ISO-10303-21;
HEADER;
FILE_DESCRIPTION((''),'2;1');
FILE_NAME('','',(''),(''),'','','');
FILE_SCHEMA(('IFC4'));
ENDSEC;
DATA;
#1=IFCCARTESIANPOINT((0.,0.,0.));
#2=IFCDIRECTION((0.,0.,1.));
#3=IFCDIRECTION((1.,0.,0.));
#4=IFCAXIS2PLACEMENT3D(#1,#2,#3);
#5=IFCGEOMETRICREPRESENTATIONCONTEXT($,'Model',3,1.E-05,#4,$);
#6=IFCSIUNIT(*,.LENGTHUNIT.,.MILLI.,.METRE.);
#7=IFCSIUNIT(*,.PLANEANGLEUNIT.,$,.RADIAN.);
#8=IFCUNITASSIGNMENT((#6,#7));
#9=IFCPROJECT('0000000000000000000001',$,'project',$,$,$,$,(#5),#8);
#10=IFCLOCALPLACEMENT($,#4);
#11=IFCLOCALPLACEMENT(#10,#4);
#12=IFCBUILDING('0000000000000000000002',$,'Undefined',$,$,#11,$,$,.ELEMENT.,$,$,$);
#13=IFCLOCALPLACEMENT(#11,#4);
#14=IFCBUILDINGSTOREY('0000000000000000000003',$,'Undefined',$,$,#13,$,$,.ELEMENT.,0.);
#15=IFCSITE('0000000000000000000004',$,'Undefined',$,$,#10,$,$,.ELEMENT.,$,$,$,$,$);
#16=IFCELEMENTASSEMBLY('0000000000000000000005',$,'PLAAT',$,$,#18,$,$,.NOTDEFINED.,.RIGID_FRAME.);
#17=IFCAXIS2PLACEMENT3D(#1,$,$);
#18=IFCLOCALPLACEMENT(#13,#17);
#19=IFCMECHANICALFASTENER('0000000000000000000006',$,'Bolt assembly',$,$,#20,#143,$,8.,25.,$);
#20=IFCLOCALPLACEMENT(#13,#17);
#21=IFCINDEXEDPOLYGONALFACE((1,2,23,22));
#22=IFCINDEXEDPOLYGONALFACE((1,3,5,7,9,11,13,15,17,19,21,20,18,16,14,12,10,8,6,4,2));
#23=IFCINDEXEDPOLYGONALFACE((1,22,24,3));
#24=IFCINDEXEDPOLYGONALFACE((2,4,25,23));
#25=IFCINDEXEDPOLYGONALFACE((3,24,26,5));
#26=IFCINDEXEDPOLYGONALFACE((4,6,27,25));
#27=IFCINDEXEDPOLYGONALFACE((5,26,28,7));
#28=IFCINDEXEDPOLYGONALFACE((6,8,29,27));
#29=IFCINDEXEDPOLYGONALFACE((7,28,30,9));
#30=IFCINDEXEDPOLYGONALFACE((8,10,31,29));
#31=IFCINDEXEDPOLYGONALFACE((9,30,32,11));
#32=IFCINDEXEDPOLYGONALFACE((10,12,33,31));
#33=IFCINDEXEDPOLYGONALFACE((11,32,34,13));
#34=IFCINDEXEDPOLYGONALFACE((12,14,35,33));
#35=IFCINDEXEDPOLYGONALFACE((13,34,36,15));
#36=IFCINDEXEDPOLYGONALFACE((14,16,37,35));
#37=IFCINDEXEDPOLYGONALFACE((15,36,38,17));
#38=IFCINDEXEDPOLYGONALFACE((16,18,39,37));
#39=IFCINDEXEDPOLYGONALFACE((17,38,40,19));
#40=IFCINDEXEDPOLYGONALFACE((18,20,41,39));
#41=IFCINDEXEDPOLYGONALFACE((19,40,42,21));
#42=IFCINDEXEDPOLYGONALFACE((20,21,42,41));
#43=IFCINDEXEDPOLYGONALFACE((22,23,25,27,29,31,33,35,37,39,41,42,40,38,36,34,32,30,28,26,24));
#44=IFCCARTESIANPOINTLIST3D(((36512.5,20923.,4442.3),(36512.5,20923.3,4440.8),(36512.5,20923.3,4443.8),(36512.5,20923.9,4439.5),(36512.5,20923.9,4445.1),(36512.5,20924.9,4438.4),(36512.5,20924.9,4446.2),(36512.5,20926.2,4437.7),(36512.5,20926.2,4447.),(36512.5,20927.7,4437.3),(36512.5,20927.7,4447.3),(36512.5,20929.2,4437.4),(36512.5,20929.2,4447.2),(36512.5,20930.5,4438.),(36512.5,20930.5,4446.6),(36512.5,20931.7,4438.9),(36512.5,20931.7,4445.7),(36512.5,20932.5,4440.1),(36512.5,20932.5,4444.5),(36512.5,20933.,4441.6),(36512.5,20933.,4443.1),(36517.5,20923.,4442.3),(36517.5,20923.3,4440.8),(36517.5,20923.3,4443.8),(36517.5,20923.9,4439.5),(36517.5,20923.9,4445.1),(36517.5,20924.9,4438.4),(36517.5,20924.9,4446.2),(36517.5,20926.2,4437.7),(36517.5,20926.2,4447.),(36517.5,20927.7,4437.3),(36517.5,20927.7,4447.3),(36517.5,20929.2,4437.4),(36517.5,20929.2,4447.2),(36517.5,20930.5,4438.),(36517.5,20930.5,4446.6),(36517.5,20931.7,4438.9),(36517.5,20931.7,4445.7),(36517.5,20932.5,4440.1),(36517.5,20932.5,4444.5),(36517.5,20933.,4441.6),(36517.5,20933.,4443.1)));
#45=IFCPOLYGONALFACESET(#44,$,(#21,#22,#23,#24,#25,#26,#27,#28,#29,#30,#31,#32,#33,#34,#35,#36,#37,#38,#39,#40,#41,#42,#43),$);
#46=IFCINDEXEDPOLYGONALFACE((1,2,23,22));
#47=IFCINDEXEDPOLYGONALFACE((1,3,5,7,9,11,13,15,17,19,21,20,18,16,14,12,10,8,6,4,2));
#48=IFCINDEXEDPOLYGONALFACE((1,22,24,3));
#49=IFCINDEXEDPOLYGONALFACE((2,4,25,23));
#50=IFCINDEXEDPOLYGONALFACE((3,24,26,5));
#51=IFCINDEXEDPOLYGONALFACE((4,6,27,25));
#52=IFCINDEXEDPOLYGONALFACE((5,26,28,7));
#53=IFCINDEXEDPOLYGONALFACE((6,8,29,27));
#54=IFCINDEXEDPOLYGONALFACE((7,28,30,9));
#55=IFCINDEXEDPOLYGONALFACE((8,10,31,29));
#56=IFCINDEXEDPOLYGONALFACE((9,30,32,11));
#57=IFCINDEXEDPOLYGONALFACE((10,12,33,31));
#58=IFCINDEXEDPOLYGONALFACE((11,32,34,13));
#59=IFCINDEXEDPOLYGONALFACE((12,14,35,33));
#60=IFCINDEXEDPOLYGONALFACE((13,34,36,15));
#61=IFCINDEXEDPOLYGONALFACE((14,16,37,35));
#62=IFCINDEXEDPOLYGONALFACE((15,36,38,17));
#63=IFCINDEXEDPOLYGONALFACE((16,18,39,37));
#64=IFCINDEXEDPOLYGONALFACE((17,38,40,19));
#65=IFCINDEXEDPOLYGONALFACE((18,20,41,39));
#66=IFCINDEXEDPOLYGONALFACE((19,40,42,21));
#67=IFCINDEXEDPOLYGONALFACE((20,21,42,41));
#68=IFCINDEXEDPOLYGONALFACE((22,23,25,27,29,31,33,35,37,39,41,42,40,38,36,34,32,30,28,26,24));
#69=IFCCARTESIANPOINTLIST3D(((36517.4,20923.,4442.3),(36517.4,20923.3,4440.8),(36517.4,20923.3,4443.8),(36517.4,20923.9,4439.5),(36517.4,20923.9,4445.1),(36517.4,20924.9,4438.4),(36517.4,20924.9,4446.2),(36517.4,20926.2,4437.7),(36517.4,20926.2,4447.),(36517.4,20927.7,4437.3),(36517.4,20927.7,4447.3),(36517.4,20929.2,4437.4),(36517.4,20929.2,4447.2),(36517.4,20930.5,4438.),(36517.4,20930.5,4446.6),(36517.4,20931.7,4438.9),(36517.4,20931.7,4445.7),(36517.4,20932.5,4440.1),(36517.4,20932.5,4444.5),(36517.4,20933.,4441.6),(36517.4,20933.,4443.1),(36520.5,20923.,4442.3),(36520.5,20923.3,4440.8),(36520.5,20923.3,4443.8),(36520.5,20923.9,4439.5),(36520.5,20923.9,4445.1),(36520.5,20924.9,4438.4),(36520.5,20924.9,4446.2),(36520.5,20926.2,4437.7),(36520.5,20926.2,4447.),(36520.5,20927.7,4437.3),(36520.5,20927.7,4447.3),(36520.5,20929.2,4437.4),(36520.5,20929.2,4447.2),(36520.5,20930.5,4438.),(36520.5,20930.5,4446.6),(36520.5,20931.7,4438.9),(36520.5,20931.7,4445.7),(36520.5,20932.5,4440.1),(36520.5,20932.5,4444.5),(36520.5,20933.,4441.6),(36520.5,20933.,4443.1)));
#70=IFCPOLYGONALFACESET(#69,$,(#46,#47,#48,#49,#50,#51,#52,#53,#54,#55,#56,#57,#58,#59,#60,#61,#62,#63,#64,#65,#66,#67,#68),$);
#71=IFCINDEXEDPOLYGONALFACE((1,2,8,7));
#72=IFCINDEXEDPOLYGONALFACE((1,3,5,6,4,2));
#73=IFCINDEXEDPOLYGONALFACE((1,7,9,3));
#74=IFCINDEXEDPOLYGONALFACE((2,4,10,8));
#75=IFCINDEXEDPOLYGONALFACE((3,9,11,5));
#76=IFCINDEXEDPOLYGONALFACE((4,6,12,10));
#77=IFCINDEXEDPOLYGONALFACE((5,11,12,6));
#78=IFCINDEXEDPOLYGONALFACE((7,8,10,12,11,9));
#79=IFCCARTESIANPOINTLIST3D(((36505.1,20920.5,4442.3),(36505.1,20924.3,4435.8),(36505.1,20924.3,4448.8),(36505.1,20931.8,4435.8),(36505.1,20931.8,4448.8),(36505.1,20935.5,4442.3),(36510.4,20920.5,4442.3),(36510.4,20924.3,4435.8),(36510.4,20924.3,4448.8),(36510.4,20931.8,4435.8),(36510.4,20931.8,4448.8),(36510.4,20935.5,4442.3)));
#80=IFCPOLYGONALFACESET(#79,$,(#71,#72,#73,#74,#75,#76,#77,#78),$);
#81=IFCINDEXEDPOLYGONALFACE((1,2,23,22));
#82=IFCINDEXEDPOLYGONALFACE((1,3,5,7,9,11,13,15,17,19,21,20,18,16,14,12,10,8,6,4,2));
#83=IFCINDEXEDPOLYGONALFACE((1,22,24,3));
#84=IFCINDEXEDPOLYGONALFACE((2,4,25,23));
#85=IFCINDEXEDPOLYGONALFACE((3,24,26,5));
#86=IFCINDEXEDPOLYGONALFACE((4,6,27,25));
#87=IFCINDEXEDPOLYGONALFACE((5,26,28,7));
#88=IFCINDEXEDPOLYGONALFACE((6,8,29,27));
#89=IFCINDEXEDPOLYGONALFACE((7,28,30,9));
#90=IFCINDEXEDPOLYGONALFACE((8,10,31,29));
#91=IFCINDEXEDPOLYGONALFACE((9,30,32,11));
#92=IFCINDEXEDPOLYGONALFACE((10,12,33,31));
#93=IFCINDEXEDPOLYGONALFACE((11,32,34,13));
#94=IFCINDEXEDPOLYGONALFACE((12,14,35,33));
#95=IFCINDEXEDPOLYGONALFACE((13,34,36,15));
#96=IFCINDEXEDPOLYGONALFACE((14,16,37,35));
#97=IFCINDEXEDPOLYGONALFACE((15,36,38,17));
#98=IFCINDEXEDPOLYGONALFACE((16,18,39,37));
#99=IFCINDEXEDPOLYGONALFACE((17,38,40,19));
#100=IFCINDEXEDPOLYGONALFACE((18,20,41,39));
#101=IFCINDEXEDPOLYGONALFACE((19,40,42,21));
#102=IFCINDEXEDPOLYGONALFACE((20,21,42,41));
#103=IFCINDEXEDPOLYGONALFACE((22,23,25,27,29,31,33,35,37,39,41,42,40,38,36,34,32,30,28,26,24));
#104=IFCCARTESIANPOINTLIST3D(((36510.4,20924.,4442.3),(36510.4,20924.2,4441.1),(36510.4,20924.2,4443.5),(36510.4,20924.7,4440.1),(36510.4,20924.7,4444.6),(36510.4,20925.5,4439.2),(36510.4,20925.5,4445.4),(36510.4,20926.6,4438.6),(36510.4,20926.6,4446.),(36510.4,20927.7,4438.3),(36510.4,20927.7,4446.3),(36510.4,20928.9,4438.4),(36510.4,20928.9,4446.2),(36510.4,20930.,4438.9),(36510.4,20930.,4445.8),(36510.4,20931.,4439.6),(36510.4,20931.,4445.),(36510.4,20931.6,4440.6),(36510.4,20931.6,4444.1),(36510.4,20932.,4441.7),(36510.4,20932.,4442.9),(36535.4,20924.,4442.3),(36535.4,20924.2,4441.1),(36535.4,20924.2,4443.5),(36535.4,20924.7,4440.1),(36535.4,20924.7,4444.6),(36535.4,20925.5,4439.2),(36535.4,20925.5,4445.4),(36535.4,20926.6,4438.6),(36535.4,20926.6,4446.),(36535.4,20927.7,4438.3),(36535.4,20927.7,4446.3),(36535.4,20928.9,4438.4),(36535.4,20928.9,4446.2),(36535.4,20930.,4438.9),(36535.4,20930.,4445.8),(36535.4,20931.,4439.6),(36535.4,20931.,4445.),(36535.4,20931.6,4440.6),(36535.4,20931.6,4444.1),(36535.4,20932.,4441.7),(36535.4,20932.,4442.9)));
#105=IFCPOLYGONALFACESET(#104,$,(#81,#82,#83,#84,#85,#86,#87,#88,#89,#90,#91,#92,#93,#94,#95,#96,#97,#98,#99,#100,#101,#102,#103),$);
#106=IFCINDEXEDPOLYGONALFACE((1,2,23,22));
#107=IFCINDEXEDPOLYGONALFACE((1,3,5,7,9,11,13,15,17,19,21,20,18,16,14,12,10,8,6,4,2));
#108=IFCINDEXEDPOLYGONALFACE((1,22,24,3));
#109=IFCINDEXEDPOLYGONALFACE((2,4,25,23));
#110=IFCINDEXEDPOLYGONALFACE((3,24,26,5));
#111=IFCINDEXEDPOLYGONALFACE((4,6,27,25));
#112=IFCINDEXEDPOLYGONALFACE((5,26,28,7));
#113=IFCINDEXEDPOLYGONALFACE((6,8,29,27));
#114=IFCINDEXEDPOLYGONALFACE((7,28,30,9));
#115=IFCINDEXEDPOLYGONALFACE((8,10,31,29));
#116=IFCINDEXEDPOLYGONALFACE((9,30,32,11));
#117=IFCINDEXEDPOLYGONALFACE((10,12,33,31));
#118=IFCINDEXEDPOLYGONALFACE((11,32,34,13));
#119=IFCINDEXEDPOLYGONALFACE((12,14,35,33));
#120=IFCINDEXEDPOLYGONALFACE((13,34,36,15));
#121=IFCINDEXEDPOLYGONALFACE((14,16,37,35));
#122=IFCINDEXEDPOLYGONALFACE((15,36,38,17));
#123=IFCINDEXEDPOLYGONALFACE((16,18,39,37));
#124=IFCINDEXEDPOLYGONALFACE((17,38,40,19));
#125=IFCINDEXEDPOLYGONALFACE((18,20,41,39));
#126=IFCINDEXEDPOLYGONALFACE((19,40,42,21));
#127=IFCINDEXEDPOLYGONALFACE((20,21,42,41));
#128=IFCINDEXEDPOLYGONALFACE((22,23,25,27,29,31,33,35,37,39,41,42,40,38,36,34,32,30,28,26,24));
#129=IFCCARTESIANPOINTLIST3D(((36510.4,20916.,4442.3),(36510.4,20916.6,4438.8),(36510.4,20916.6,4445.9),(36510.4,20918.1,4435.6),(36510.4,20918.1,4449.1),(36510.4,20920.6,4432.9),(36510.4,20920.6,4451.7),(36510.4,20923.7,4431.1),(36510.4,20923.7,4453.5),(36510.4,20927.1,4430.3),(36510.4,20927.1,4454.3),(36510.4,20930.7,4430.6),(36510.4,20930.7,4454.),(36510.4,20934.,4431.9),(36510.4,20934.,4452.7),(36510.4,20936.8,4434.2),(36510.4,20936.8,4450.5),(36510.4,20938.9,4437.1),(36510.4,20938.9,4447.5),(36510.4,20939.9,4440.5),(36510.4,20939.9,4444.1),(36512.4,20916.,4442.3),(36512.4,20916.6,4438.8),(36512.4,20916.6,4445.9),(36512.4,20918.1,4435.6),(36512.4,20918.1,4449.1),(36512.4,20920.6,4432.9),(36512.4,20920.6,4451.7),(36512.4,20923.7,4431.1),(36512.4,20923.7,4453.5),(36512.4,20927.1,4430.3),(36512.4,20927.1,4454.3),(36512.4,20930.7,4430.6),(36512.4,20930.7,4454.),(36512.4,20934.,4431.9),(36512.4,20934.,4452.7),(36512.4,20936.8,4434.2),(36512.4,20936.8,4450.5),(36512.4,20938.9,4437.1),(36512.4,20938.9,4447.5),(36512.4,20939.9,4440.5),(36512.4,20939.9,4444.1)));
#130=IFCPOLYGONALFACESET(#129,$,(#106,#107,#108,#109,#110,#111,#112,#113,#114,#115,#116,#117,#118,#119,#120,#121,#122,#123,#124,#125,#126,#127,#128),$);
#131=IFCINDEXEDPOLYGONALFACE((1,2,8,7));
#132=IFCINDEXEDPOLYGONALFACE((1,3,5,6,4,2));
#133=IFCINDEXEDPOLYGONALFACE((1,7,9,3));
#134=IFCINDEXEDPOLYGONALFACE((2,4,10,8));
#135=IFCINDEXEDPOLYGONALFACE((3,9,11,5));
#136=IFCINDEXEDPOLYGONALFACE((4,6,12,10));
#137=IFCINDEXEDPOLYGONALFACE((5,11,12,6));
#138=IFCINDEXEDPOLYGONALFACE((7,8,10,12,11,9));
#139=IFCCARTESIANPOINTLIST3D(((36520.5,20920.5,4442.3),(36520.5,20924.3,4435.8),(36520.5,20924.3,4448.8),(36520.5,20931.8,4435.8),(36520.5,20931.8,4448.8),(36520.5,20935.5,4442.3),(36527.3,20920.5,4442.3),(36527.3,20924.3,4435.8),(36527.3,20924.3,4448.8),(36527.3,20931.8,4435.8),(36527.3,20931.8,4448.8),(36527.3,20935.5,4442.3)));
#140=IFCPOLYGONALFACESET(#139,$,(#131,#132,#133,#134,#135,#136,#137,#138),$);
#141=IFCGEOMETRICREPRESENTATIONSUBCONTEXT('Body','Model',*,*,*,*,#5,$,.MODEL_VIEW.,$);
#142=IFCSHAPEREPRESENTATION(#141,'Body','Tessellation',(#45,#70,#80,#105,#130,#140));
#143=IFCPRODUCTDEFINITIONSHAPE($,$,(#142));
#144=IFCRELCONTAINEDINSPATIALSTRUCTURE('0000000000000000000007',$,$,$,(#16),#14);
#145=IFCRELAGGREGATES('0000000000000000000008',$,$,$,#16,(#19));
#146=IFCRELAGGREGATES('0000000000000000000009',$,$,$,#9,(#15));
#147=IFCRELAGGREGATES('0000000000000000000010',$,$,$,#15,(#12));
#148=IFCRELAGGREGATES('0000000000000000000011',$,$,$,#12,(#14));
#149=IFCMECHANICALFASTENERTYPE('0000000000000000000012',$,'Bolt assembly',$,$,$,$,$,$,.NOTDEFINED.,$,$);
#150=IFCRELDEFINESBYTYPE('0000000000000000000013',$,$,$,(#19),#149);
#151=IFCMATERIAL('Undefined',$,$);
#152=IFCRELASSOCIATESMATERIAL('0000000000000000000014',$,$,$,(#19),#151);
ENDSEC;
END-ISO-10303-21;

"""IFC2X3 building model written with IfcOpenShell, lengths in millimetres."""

from ifc_helpers import new_model, si_unit, frame, origin_with_axes, origin_2d_with_axis, place, context, subcontext, project, spatial, polyline, circle, outline, extrude, source, transform, mapped, material, type_object, element, aggregate, save


model = new_model("IFC2X3")

# Units and contexts
model_context = context("Model", 3, precision=1e-05, world=origin_with_axes())
body_context = subcontext(model_context, "Body", "Model", "MODEL_VIEW")
ifc_project = project(units=[si_unit("LENGTHUNIT", "METRE", prefix="MILLI"), si_unit("PLANEANGLEUNIT", "RADIAN")], contexts=[model_context])

# Site, building, storey
site_placement = place(None, origin_with_axes())
site = spatial("IfcSite", under=ifc_project, at=site_placement, Name="Undefined", CompositionType="ELEMENT")
building_placement = place(site_placement, origin_with_axes())
building = spatial("IfcBuilding", under=site, at=building_placement, Name="Undefined", CompositionType="ELEMENT")
storey_placement = place(building_placement, origin_with_axes())
storey = spatial("IfcBuildingStorey", under=building, at=storey_placement, Name="Undefined", CompositionType="ELEMENT", Elevation=0.0)

# Element assembly, mechanical fastener
ifc_material_1 = material(Name="Undefined")
mechanical_fastener_type = type_object("IfcMechanicalFastenerType", Name="Bolt assembly")
assembly_1_placement = place(storey_placement, origin_with_axes())
assembly_1 = element("IfcElementAssembly", 1, at=assembly_1_placement, inside=storey, Name="PLAAT", AssemblyPlace="NOTDEFINED", PredefinedType="RIGID_FRAME")
shared_shape_1 = source(origin_with_axes(), body_context, "Body", "SweptSolid", [
    extrude(circle(Radius=5.0, at=origin_2d_with_axis()), frame((0.0, 7.5, 0.0), z_axis=(0.0, 1.0, 0.0), x_axis=(1.0, 0.0, 0.0)), (0.0, 0.0, 1.0), 5.0),
    extrude(circle(Radius=5.0, at=origin_2d_with_axis()), frame((0.0, 12.4, 0.0), z_axis=(0.0, 1.0, 0.0), x_axis=(1.0, 0.0, 0.0)), (0.0, 0.0, 1.0), 3.1),
    extrude(outline(polyline([(7.5, 0.0), (3.8, 6.5), (-3.8, 6.5), (-7.5, 0.0), (-3.8, -6.5), (3.8, -6.5), (7.5, 0.0)])), frame((0.0, 0.1, 0.0), z_axis=(0.0, 1.0, 0.0), x_axis=(1.0, 0.0, 0.0)), (0.0, 0.0, 1.0), 5.3),
    extrude(circle(Radius=4.0, at=origin_2d_with_axis()), frame((0.0, 5.4, 0.0), z_axis=(0.0, 1.0, 0.0), x_axis=(1.0, 0.0, 0.0)), (0.0, 0.0, 1.0), 25.0),
    extrude(circle(Radius=12.0, at=origin_2d_with_axis()), frame((0.0, 5.4, 0.0), z_axis=(0.0, 1.0, 0.0), x_axis=(1.0, 0.0, 0.0)), (0.0, 0.0, 1.0), 2.0),
    extrude(outline(polyline([(7.5, 0.0), (3.8, 6.5), (-3.8, 6.5), (-7.5, 0.0), (-3.8, -6.5), (3.8, -6.5), (7.5, 0.0)])), frame((0.0, 15.5, 0.0), z_axis=(0.0, 1.0, 0.0), x_axis=(1.0, 0.0, 0.0)), (0.0, 0.0, 1.0), 6.8),
])
mechanical_fastener_1_placement = place(assembly_1_placement, frame((36505.0, 20928.0, 4442.3), z_axis=(0.0, 0.000002, 1.0), x_axis=(0.0, -1.0, 0.000002)))
mechanical_fastener_1 = element("IfcMechanicalFastener", 2, at=mechanical_fastener_1_placement, type_object=mechanical_fastener_type, material=ifc_material_1, Name="Bolt assembly", NominalDiameter=8.0, NominalLength=25.0, context=body_context, shape_type="MappedRepresentation", body=[
    mapped(shared_shape_1, transform((0.0, 0.0, 0.0))),
])

aggregate(assembly_1, [mechanical_fastener_1])

save(model, "model.ifc")
